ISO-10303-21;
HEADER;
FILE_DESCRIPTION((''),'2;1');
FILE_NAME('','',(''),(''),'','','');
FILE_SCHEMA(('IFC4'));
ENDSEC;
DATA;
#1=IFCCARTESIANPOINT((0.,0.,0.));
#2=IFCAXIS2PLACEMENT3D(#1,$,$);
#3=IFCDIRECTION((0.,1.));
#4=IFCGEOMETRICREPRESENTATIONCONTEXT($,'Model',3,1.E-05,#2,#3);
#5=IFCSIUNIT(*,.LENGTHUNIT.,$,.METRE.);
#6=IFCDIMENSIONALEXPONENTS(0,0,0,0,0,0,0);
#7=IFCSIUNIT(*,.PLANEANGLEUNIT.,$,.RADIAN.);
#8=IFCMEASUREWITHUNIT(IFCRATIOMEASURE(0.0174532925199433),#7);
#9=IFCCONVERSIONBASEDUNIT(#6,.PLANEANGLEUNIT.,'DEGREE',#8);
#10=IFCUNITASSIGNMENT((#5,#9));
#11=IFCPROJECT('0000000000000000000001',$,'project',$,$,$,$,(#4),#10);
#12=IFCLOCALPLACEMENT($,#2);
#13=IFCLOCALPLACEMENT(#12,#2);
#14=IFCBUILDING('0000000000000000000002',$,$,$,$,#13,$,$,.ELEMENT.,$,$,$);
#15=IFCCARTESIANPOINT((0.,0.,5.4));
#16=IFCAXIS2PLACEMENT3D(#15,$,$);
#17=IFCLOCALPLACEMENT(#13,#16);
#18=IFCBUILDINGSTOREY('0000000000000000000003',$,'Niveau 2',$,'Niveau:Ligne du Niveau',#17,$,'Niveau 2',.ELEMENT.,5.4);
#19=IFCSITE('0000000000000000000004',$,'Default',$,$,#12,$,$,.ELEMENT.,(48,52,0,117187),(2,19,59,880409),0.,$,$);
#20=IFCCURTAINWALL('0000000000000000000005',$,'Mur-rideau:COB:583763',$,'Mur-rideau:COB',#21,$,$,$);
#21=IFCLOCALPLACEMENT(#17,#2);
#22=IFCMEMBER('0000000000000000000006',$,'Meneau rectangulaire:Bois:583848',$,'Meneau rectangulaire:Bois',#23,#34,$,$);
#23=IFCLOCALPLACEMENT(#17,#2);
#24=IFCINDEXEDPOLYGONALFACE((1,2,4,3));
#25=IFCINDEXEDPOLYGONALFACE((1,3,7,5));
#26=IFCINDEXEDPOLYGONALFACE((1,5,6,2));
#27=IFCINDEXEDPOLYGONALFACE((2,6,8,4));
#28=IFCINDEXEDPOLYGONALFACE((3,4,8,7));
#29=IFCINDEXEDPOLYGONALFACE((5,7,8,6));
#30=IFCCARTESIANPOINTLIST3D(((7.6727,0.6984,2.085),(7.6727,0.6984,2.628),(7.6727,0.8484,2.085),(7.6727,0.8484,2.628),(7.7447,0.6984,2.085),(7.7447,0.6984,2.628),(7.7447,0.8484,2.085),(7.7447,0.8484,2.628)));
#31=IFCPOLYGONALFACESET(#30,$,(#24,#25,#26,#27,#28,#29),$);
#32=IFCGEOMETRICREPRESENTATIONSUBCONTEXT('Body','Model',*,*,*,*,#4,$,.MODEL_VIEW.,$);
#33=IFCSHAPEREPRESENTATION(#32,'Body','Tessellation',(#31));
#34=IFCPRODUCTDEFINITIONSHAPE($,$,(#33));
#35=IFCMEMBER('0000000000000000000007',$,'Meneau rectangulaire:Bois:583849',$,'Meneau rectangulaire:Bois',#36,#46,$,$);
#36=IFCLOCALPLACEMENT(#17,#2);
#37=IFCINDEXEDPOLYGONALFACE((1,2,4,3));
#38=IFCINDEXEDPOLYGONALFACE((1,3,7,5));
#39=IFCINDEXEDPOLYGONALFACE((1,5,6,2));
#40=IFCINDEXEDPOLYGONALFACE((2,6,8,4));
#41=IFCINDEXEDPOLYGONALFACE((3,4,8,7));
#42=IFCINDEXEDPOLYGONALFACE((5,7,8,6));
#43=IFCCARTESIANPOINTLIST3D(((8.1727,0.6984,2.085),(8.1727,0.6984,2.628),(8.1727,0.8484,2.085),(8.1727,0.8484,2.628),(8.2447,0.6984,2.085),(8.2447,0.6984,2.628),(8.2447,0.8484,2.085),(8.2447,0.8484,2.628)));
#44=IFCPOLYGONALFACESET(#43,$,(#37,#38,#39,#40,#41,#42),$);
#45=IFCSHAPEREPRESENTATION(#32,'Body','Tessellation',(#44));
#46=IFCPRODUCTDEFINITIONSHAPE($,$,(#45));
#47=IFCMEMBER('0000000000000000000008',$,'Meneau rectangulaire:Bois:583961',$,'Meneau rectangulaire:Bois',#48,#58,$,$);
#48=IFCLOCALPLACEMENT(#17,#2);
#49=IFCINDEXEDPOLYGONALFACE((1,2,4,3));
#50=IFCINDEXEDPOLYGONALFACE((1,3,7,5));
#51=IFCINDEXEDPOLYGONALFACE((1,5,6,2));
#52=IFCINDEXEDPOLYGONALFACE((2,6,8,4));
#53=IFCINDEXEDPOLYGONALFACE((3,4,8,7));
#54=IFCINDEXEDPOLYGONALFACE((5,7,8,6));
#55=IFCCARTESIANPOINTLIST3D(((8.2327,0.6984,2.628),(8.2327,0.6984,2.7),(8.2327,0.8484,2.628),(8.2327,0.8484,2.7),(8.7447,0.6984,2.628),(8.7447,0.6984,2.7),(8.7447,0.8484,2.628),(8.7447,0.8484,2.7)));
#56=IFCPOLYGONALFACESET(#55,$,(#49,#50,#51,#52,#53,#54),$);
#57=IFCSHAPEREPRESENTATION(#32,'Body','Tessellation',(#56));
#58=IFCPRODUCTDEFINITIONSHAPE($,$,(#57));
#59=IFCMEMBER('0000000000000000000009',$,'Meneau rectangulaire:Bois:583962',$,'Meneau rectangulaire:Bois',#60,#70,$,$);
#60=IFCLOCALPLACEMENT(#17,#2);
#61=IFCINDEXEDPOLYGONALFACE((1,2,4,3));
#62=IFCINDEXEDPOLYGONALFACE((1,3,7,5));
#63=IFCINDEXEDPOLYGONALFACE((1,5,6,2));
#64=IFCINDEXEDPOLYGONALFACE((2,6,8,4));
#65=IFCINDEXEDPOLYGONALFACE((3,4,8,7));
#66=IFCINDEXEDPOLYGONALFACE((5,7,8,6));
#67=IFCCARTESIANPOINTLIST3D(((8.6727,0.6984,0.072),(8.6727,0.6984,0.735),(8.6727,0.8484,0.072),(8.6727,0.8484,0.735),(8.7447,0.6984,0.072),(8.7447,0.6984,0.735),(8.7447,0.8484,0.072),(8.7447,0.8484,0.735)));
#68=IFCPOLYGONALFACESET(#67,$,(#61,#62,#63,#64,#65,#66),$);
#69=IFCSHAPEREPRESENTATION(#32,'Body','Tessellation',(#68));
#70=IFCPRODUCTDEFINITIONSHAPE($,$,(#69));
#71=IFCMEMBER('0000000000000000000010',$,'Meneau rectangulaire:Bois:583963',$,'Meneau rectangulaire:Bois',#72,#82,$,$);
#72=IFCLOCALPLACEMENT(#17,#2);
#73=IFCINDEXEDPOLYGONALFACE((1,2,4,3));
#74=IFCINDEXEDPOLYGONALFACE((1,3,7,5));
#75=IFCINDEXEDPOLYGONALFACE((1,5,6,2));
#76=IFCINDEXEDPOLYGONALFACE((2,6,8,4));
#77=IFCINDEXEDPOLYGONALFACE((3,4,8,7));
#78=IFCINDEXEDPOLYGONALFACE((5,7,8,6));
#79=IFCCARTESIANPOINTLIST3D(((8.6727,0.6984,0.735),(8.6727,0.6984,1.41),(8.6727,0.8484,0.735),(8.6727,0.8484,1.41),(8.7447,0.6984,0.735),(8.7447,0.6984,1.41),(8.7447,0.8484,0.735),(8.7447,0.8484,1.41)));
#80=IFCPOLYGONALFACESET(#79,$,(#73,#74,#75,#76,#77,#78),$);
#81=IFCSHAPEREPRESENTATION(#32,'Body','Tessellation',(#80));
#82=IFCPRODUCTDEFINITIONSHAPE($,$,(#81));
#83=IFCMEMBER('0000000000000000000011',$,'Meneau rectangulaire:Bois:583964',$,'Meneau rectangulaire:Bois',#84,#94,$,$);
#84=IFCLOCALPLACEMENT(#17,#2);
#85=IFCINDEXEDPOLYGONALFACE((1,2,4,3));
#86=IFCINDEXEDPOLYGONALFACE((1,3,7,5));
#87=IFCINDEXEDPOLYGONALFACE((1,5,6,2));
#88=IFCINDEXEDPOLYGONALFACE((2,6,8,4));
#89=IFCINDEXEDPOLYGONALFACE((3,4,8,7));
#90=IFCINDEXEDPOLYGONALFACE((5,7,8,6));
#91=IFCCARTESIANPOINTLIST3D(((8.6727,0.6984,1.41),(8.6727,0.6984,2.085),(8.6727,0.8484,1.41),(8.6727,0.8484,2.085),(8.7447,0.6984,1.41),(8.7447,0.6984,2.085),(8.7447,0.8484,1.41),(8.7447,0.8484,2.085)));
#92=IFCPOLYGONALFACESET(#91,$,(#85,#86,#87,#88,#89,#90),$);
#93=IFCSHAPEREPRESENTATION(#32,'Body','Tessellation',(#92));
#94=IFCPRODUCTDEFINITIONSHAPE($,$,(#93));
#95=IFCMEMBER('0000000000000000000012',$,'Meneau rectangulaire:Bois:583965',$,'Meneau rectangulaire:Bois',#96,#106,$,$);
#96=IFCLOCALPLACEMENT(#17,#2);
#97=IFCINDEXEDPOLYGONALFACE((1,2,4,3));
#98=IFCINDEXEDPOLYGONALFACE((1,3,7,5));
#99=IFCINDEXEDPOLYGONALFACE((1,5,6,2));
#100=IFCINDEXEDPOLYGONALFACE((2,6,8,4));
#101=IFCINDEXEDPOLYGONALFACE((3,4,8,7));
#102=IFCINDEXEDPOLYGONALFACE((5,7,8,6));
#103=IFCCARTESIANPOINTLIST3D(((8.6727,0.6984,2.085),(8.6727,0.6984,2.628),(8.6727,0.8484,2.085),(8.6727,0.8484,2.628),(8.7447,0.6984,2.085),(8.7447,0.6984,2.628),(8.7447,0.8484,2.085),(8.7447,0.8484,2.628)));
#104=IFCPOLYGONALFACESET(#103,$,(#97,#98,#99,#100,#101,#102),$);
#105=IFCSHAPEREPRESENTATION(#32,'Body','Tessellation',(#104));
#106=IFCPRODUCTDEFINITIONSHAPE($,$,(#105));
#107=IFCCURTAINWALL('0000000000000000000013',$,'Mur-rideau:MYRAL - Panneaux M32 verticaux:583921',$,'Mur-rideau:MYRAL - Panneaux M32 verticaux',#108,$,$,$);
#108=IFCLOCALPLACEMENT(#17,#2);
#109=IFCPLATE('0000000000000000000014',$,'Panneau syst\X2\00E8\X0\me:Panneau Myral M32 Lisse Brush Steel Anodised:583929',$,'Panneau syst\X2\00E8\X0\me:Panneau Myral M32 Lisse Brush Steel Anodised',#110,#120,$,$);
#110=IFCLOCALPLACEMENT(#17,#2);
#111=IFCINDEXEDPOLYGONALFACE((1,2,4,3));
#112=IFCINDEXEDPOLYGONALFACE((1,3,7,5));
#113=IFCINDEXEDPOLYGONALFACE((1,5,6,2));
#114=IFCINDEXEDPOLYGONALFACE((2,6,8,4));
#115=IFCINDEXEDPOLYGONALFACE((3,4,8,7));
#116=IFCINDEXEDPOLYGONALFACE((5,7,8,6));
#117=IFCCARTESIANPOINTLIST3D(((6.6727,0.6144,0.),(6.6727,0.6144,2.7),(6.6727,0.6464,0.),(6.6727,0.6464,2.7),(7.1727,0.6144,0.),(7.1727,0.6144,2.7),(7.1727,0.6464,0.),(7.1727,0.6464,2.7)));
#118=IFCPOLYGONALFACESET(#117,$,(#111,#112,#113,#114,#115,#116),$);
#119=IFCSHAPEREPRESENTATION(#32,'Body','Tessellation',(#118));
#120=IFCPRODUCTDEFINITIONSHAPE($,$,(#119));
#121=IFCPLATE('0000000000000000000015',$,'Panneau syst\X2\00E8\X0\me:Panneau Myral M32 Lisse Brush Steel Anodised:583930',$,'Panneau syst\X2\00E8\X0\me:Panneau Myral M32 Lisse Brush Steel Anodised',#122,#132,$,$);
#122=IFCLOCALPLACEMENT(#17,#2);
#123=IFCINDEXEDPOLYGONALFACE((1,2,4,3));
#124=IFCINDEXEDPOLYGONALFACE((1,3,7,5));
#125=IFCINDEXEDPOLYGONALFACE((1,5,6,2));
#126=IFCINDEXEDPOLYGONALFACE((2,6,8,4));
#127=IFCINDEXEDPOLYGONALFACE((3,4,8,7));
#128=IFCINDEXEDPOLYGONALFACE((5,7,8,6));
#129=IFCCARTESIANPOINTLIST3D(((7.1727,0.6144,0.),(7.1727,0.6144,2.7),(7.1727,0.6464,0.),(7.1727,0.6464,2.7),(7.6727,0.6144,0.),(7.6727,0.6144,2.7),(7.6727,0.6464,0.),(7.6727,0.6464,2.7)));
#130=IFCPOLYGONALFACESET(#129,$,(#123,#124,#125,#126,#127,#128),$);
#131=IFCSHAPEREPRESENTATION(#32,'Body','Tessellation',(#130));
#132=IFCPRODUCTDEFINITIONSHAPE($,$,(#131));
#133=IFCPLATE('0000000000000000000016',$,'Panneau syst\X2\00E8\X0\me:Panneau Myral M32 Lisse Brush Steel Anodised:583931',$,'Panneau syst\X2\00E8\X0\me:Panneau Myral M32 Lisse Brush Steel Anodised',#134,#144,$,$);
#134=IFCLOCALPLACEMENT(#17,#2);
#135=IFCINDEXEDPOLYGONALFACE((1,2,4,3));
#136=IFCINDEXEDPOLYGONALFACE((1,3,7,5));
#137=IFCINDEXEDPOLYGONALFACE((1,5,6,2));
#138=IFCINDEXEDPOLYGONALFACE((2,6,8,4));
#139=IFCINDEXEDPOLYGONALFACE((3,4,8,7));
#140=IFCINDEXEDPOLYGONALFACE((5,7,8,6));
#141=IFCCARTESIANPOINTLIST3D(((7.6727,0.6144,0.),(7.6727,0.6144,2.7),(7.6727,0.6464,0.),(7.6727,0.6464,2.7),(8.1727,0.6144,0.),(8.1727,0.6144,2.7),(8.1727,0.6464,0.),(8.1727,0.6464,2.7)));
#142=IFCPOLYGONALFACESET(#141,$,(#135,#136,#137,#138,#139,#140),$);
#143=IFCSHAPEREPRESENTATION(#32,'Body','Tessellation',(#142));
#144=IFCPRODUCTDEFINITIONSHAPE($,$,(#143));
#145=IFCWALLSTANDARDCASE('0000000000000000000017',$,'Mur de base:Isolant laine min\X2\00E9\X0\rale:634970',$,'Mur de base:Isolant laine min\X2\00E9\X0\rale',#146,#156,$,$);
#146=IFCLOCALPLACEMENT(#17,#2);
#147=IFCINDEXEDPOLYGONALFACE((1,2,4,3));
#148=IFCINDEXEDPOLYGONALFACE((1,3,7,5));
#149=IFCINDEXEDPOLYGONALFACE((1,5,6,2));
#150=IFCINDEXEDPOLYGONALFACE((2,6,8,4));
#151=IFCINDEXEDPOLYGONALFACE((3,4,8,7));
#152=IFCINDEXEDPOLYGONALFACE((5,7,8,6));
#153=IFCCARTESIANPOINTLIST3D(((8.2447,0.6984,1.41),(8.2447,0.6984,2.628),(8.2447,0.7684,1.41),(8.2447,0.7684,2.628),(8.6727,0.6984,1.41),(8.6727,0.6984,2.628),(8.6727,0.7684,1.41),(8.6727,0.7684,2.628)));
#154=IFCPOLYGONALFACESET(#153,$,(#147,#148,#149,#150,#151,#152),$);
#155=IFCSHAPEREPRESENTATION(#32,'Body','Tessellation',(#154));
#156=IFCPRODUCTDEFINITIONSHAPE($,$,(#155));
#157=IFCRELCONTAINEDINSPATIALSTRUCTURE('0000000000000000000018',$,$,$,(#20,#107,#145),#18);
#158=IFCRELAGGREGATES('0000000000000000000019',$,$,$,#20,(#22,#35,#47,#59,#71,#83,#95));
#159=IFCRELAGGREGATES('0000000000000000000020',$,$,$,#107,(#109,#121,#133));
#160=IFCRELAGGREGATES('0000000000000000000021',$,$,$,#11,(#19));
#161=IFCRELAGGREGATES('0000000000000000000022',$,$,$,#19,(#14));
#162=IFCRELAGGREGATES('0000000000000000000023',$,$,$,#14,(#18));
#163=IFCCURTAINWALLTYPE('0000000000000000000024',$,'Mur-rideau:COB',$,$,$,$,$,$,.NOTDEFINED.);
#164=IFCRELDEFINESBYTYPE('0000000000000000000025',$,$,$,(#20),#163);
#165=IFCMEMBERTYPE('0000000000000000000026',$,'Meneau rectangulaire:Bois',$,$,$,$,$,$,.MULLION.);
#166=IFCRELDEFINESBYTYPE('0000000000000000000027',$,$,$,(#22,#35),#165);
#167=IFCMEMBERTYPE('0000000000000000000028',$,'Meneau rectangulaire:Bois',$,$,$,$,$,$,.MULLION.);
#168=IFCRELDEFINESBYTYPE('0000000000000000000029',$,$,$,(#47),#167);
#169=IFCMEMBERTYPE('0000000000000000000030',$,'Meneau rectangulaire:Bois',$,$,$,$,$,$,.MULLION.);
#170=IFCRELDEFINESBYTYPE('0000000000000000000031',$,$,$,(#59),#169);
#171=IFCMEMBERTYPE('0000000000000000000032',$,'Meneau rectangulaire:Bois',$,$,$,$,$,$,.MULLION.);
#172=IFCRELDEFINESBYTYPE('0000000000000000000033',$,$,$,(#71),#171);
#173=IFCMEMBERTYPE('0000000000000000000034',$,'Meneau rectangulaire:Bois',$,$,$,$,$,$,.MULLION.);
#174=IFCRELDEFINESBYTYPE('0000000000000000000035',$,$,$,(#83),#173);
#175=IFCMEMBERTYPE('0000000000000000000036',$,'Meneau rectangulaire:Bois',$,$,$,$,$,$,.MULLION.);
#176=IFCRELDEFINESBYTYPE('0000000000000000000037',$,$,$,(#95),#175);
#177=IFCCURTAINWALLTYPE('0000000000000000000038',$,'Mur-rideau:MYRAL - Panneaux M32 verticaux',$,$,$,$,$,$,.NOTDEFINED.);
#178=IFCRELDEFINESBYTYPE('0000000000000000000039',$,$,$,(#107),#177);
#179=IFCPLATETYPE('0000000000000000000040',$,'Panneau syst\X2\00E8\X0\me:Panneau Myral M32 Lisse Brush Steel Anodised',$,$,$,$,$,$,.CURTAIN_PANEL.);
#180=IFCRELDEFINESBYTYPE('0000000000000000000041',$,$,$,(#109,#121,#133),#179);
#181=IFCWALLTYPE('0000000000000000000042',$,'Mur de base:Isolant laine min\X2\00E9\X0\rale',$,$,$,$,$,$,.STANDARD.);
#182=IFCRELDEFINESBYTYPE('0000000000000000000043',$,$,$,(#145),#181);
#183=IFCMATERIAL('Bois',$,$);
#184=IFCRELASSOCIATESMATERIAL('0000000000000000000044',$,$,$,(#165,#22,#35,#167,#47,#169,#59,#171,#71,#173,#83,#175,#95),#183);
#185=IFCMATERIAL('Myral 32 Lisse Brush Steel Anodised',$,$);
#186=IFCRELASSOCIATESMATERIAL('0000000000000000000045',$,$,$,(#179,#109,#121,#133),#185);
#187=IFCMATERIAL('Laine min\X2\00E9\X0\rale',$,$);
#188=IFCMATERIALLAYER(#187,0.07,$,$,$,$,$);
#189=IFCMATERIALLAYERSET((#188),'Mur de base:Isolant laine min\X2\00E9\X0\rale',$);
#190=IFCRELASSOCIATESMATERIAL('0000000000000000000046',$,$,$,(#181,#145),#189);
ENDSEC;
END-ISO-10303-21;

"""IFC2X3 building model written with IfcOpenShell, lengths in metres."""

from ifc_helpers import new_model, entity, si_unit, converted_unit, direction, frame, frame_2d, origin, origin_2d_with_axis, place, context, subcontext, project, spatial, rectangle, extrude, source, transform, mapped, material, layer, layer_set, layer_usage, type_object, type_shapes, element, aggregate, save


model = new_model("IFC2X3")

# Units and contexts
model_context = context("Model", 3, precision=1e-05, world=origin(), true_north=direction((0.0, 1.0)))
body_context = subcontext(model_context, "Body", "Model", "MODEL_VIEW")
ifc_project = project(units=[si_unit("LENGTHUNIT", "METRE"), converted_unit("PLANEANGLEUNIT", "DEGREE", entity("IfcRatioMeasure", 0.0174532925199433), si_unit("PLANEANGLEUNIT", "RADIAN"), dimensions=[0, 0, 0, 0, 0, 0, 0])], contexts=[model_context])

# Site, building, storey
site_placement = place(None, origin())
site = spatial("IfcSite", under=ifc_project, at=site_placement, Name="Default", CompositionType="ELEMENT", RefLatitude=(48, 52, 0, 117187), RefLongitude=(2, 19, 59, 880409), RefElevation=0.0)
building_placement = place(site_placement, origin())
building = spatial("IfcBuilding", under=site, at=building_placement, CompositionType="ELEMENT")
storey_placement = place(building_placement, frame((0.0, 0.0, 5.4)))
storey = spatial("IfcBuildingStorey", under=building, at=storey_placement, Name="Niveau 2", ObjectType="Niveau:Ligne du Niveau", LongName="Niveau 2", CompositionType="ELEMENT", Elevation=5.4)

# Curtain wall, members
curtain_wall_type_1 = type_object("IfcCurtainWallType", Name="Mur-rideau:COB", PredefinedType="NOTDEFINED")
curtain_wall_1_placement = place(storey_placement, frame((0.0, 0.0, -5.4)))
curtain_wall_1 = element("IfcCurtainWall", 1, at=curtain_wall_1_placement, inside=storey, type_object=curtain_wall_type_1, Name="Mur-rideau:COB:583763", ObjectType="Mur-rideau:COB")
ifc_material_1 = material(Name="Bois")
member_type_1 = type_object("IfcMemberType", Name="Meneau rectangulaire:Bois", PredefinedType="MULLION", material=ifc_material_1)
shared_shape_1 = source(origin(), body_context, "Body", "SweptSolid", [
    extrude(rectangle(XDim=0.15, YDim=0.072, at=origin_2d_with_axis()), frame((-0.024, 0.0, -0.543), z_axis=(0.0, 0.0, 1.0), x_axis=(0.0, -1.0, 0.0)), (0.0, 0.0, 1.0), 0.543),
])
type_shapes(member_type_1, [shared_shape_1])
member_1_placement = place(storey_placement, frame((7.7327, 0.7734, 2.085), z_axis=(0.0, 0.0, -1.0), x_axis=(1.0, 0.0, 0.0)))
member_1 = element("IfcMember", 2, at=member_1_placement, type_object=member_type_1, material=ifc_material_1, Name="Meneau rectangulaire:Bois:583848", ObjectType="Meneau rectangulaire:Bois", context=body_context, shape_type="MappedRepresentation", body=[
    mapped(shared_shape_1, transform((0.0, 0.0, 0.0), scale=1.0)),
])
member_2_placement = place(storey_placement, frame((8.2327, 0.7734, 2.085), z_axis=(0.0, 0.0, -1.0), x_axis=(1.0, 0.0, 0.0)))
member_2 = element("IfcMember", 3, at=member_2_placement, type_object=member_type_1, material=ifc_material_1, Name="Meneau rectangulaire:Bois:583849", ObjectType="Meneau rectangulaire:Bois", context=body_context, shape_type="MappedRepresentation", body=[
    mapped(shared_shape_1, transform((0.0, 0.0, 0.0), scale=1.0)),
])
member_type_2 = type_object("IfcMemberType", Name="Meneau rectangulaire:Bois", PredefinedType="MULLION", material=ifc_material_1)
shared_shape_2 = source(origin(), body_context, "Body", "SweptSolid", [
    extrude(rectangle(XDim=0.15, YDim=0.072, at=origin_2d_with_axis()), frame((-0.036, 0.0, -0.512), z_axis=(0.0, 0.0, 1.0), x_axis=(0.0, -1.0, 0.0)), (0.0, 0.0, 1.0), 0.512),
])
type_shapes(member_type_2, [shared_shape_2])
member_3_placement = place(storey_placement, frame((8.7447, 0.7734, 2.7), z_axis=(1.0, 0.0, 0.0), x_axis=(0.0, 0.0, 1.0)))
member_3 = element("IfcMember", 4, at=member_3_placement, type_object=member_type_2, material=ifc_material_1, Name="Meneau rectangulaire:Bois:583961", ObjectType="Meneau rectangulaire:Bois", context=body_context, shape_type="MappedRepresentation", body=[
    mapped(shared_shape_2, transform((0.0, 0.0, 0.0), scale=1.0)),
])
member_type_3 = type_object("IfcMemberType", Name="Meneau rectangulaire:Bois", PredefinedType="MULLION", material=ifc_material_1)
shared_shape_3 = source(origin(), body_context, "Body", "SweptSolid", [
    extrude(rectangle(XDim=0.15, YDim=0.072, at=origin_2d_with_axis()), frame((-0.024, 0.0, -0.663), z_axis=(0.0, 0.0, 1.0), x_axis=(0.0, -1.0, 0.0)), (0.0, 0.0, 1.0), 0.663),
])
type_shapes(member_type_3, [shared_shape_3])
member_4_placement = place(storey_placement, frame((8.7327, 0.7734, 0.072), z_axis=(0.0, 0.0, -1.0), x_axis=(1.0, 0.0, 0.0)))
member_4 = element("IfcMember", 5, at=member_4_placement, type_object=member_type_3, material=ifc_material_1, Name="Meneau rectangulaire:Bois:583962", ObjectType="Meneau rectangulaire:Bois", context=body_context, shape_type="MappedRepresentation", body=[
    mapped(shared_shape_3, transform((0.0, 0.0, 0.0), scale=1.0)),
])
member_type_4 = type_object("IfcMemberType", Name="Meneau rectangulaire:Bois", PredefinedType="MULLION", material=ifc_material_1)
shared_shape_4 = source(origin(), body_context, "Body", "SweptSolid", [
    extrude(rectangle(XDim=0.15, YDim=0.072, at=origin_2d_with_axis()), frame((-0.024, 0.0, -0.675), z_axis=(0.0, 0.0, 1.0), x_axis=(0.0, -1.0, 0.0)), (0.0, 0.0, 1.0), 0.675),
])
type_shapes(member_type_4, [shared_shape_4])
member_5_placement = place(storey_placement, frame((8.7327, 0.7734, 0.735), z_axis=(0.0, 0.0, -1.0), x_axis=(1.0, 0.0, 0.0)))
member_5 = element("IfcMember", 6, at=member_5_placement, type_object=member_type_4, material=ifc_material_1, Name="Meneau rectangulaire:Bois:583963", ObjectType="Meneau rectangulaire:Bois", context=body_context, shape_type="MappedRepresentation", body=[
    mapped(shared_shape_4, transform((0.0, 0.0, 0.0), scale=1.0)),
])
member_type_5 = type_object("IfcMemberType", Name="Meneau rectangulaire:Bois", PredefinedType="MULLION", material=ifc_material_1)
shared_shape_5 = source(origin(), body_context, "Body", "SweptSolid", [
    extrude(rectangle(XDim=0.15, YDim=0.072, at=origin_2d_with_axis()), frame((-0.024, 0.0, -0.675), z_axis=(0.0, 0.0, 1.0), x_axis=(0.0, -1.0, 0.0)), (0.0, 0.0, 1.0), 0.675),
])
type_shapes(member_type_5, [shared_shape_5])
member_6_placement = place(storey_placement, frame((8.7327, 0.7734, 1.41), z_axis=(0.0, 0.0, -1.0), x_axis=(1.0, 0.0, 0.0)))
member_6 = element("IfcMember", 7, at=member_6_placement, type_object=member_type_5, material=ifc_material_1, Name="Meneau rectangulaire:Bois:583964", ObjectType="Meneau rectangulaire:Bois", context=body_context, shape_type="MappedRepresentation", body=[
    mapped(shared_shape_5, transform((0.0, 0.0, 0.0), scale=1.0)),
])
member_type_6 = type_object("IfcMemberType", Name="Meneau rectangulaire:Bois", PredefinedType="MULLION", material=ifc_material_1)
shared_shape_6 = source(origin(), body_context, "Body", "SweptSolid", [
    extrude(rectangle(XDim=0.15, YDim=0.072, at=origin_2d_with_axis()), frame((-0.024, 0.0, -0.543), z_axis=(0.0, 0.0, 1.0), x_axis=(0.0, -1.0, 0.0)), (0.0, 0.0, 1.0), 0.543),
])
type_shapes(member_type_6, [shared_shape_6])
member_7_placement = place(storey_placement, frame((8.7327, 0.7734, 2.085), z_axis=(0.0, 0.0, -1.0), x_axis=(1.0, 0.0, 0.0)))
member_7 = element("IfcMember", 8, at=member_7_placement, type_object=member_type_6, material=ifc_material_1, Name="Meneau rectangulaire:Bois:583965", ObjectType="Meneau rectangulaire:Bois", context=body_context, shape_type="MappedRepresentation", body=[
    mapped(shared_shape_6, transform((0.0, 0.0, 0.0), scale=1.0)),
])
aggregate(curtain_wall_1, [member_1, member_2, member_3, member_4, member_5, member_6, member_7])

# Curtain wall, plates
curtain_wall_type_2 = type_object("IfcCurtainWallType", Name="Mur-rideau:MYRAL - Panneaux M32 verticaux", PredefinedType="NOTDEFINED")
curtain_wall_2_placement = place(storey_placement, frame((0.0, 0.0, -5.4)))
curtain_wall_2 = element("IfcCurtainWall", 9, at=curtain_wall_2_placement, inside=storey, type_object=curtain_wall_type_2, Name="Mur-rideau:MYRAL - Panneaux M32 verticaux:583921", ObjectType="Mur-rideau:MYRAL - Panneaux M32 verticaux")
ifc_material_2 = material(Name="Myral 32 Lisse Brush Steel Anodised")
plate_type = type_object("IfcPlateType", Name="Panneau système:Panneau Myral M32 Lisse Brush Steel Anodised", PredefinedType="CURTAIN_PANEL", material=ifc_material_2)
shared_shape_7 = source(origin(), body_context, "Body", "SweptSolid", [
    extrude(rectangle(XDim=0.032, YDim=0.5, at=origin_2d_with_axis()), frame((0.0, -0.016, 0.0), z_axis=(0.0, 0.0, 1.0), x_axis=(0.0, 1.0, 0.0)), (0.0, 0.0, 1.0), 2.7),
])
type_shapes(plate_type, [shared_shape_7])
plate_1_placement = place(curtain_wall_2_placement, frame((6.9227, 0.6464, 5.4)))
plate_1 = element("IfcPlate", 10, at=plate_1_placement, type_object=plate_type, material=ifc_material_2, Name="Panneau système:Panneau Myral M32 Lisse Brush Steel Anodised:583929", ObjectType="Panneau système:Panneau Myral M32 Lisse Brush Steel Anodised", context=body_context, shape_type="MappedRepresentation", body=[
    mapped(shared_shape_7, transform((0.0, 0.0, 0.0), scale=1.0)),
])
plate_2_placement = place(curtain_wall_2_placement, frame((7.4227, 0.6464, 5.4)))
plate_2 = element("IfcPlate", 11, at=plate_2_placement, type_object=plate_type, material=ifc_material_2, Name="Panneau système:Panneau Myral M32 Lisse Brush Steel Anodised:583930", ObjectType="Panneau système:Panneau Myral M32 Lisse Brush Steel Anodised", context=body_context, shape_type="MappedRepresentation", body=[
    mapped(shared_shape_7, transform((0.0, 0.0, 0.0), scale=1.0)),
])
plate_3_placement = place(curtain_wall_2_placement, frame((7.9227, 0.6464, 5.4)))
plate_3 = element("IfcPlate", 12, at=plate_3_placement, type_object=plate_type, material=ifc_material_2, Name="Panneau système:Panneau Myral M32 Lisse Brush Steel Anodised:583931", ObjectType="Panneau système:Panneau Myral M32 Lisse Brush Steel Anodised", context=body_context, shape_type="MappedRepresentation", body=[
    mapped(shared_shape_7, transform((0.0, 0.0, 0.0), scale=1.0)),
])
aggregate(curtain_wall_2, [plate_1, plate_2, plate_3])

# Wall
ifc_material_3 = material(Name="Laine minérale")
ifc_layer = layer(ifc_material_3, 0.07)
ifc_layer_set = layer_set([ifc_layer], Name="Mur de base:Isolant laine minérale")
ifc_layer_usage = layer_usage(ifc_layer_set, "AXIS2", "NEGATIVE", 0.035)
wall_type = type_object("IfcWallType", Name="Mur de base:Isolant laine minérale", PredefinedType="STANDARD", material=ifc_layer_set)
wall_placement = place(storey_placement, frame((8.2447, 0.7334, 1.41)))
element("IfcWallStandardCase", 13, at=wall_placement, inside=storey, type_object=wall_type, material=ifc_layer_usage, Name="Mur de base:Isolant laine minérale:634970", ObjectType="Mur de base:Isolant laine minérale", context=body_context, shape_type="SweptSolid", body=[
    extrude(rectangle(XDim=0.428, YDim=0.07, at=frame_2d((0.214, 0.0), x_axis=(-1.0, 0.0))), origin(), (0.0, 0.0, 1.0), 1.218),
])

save(model, "model.ifc")
